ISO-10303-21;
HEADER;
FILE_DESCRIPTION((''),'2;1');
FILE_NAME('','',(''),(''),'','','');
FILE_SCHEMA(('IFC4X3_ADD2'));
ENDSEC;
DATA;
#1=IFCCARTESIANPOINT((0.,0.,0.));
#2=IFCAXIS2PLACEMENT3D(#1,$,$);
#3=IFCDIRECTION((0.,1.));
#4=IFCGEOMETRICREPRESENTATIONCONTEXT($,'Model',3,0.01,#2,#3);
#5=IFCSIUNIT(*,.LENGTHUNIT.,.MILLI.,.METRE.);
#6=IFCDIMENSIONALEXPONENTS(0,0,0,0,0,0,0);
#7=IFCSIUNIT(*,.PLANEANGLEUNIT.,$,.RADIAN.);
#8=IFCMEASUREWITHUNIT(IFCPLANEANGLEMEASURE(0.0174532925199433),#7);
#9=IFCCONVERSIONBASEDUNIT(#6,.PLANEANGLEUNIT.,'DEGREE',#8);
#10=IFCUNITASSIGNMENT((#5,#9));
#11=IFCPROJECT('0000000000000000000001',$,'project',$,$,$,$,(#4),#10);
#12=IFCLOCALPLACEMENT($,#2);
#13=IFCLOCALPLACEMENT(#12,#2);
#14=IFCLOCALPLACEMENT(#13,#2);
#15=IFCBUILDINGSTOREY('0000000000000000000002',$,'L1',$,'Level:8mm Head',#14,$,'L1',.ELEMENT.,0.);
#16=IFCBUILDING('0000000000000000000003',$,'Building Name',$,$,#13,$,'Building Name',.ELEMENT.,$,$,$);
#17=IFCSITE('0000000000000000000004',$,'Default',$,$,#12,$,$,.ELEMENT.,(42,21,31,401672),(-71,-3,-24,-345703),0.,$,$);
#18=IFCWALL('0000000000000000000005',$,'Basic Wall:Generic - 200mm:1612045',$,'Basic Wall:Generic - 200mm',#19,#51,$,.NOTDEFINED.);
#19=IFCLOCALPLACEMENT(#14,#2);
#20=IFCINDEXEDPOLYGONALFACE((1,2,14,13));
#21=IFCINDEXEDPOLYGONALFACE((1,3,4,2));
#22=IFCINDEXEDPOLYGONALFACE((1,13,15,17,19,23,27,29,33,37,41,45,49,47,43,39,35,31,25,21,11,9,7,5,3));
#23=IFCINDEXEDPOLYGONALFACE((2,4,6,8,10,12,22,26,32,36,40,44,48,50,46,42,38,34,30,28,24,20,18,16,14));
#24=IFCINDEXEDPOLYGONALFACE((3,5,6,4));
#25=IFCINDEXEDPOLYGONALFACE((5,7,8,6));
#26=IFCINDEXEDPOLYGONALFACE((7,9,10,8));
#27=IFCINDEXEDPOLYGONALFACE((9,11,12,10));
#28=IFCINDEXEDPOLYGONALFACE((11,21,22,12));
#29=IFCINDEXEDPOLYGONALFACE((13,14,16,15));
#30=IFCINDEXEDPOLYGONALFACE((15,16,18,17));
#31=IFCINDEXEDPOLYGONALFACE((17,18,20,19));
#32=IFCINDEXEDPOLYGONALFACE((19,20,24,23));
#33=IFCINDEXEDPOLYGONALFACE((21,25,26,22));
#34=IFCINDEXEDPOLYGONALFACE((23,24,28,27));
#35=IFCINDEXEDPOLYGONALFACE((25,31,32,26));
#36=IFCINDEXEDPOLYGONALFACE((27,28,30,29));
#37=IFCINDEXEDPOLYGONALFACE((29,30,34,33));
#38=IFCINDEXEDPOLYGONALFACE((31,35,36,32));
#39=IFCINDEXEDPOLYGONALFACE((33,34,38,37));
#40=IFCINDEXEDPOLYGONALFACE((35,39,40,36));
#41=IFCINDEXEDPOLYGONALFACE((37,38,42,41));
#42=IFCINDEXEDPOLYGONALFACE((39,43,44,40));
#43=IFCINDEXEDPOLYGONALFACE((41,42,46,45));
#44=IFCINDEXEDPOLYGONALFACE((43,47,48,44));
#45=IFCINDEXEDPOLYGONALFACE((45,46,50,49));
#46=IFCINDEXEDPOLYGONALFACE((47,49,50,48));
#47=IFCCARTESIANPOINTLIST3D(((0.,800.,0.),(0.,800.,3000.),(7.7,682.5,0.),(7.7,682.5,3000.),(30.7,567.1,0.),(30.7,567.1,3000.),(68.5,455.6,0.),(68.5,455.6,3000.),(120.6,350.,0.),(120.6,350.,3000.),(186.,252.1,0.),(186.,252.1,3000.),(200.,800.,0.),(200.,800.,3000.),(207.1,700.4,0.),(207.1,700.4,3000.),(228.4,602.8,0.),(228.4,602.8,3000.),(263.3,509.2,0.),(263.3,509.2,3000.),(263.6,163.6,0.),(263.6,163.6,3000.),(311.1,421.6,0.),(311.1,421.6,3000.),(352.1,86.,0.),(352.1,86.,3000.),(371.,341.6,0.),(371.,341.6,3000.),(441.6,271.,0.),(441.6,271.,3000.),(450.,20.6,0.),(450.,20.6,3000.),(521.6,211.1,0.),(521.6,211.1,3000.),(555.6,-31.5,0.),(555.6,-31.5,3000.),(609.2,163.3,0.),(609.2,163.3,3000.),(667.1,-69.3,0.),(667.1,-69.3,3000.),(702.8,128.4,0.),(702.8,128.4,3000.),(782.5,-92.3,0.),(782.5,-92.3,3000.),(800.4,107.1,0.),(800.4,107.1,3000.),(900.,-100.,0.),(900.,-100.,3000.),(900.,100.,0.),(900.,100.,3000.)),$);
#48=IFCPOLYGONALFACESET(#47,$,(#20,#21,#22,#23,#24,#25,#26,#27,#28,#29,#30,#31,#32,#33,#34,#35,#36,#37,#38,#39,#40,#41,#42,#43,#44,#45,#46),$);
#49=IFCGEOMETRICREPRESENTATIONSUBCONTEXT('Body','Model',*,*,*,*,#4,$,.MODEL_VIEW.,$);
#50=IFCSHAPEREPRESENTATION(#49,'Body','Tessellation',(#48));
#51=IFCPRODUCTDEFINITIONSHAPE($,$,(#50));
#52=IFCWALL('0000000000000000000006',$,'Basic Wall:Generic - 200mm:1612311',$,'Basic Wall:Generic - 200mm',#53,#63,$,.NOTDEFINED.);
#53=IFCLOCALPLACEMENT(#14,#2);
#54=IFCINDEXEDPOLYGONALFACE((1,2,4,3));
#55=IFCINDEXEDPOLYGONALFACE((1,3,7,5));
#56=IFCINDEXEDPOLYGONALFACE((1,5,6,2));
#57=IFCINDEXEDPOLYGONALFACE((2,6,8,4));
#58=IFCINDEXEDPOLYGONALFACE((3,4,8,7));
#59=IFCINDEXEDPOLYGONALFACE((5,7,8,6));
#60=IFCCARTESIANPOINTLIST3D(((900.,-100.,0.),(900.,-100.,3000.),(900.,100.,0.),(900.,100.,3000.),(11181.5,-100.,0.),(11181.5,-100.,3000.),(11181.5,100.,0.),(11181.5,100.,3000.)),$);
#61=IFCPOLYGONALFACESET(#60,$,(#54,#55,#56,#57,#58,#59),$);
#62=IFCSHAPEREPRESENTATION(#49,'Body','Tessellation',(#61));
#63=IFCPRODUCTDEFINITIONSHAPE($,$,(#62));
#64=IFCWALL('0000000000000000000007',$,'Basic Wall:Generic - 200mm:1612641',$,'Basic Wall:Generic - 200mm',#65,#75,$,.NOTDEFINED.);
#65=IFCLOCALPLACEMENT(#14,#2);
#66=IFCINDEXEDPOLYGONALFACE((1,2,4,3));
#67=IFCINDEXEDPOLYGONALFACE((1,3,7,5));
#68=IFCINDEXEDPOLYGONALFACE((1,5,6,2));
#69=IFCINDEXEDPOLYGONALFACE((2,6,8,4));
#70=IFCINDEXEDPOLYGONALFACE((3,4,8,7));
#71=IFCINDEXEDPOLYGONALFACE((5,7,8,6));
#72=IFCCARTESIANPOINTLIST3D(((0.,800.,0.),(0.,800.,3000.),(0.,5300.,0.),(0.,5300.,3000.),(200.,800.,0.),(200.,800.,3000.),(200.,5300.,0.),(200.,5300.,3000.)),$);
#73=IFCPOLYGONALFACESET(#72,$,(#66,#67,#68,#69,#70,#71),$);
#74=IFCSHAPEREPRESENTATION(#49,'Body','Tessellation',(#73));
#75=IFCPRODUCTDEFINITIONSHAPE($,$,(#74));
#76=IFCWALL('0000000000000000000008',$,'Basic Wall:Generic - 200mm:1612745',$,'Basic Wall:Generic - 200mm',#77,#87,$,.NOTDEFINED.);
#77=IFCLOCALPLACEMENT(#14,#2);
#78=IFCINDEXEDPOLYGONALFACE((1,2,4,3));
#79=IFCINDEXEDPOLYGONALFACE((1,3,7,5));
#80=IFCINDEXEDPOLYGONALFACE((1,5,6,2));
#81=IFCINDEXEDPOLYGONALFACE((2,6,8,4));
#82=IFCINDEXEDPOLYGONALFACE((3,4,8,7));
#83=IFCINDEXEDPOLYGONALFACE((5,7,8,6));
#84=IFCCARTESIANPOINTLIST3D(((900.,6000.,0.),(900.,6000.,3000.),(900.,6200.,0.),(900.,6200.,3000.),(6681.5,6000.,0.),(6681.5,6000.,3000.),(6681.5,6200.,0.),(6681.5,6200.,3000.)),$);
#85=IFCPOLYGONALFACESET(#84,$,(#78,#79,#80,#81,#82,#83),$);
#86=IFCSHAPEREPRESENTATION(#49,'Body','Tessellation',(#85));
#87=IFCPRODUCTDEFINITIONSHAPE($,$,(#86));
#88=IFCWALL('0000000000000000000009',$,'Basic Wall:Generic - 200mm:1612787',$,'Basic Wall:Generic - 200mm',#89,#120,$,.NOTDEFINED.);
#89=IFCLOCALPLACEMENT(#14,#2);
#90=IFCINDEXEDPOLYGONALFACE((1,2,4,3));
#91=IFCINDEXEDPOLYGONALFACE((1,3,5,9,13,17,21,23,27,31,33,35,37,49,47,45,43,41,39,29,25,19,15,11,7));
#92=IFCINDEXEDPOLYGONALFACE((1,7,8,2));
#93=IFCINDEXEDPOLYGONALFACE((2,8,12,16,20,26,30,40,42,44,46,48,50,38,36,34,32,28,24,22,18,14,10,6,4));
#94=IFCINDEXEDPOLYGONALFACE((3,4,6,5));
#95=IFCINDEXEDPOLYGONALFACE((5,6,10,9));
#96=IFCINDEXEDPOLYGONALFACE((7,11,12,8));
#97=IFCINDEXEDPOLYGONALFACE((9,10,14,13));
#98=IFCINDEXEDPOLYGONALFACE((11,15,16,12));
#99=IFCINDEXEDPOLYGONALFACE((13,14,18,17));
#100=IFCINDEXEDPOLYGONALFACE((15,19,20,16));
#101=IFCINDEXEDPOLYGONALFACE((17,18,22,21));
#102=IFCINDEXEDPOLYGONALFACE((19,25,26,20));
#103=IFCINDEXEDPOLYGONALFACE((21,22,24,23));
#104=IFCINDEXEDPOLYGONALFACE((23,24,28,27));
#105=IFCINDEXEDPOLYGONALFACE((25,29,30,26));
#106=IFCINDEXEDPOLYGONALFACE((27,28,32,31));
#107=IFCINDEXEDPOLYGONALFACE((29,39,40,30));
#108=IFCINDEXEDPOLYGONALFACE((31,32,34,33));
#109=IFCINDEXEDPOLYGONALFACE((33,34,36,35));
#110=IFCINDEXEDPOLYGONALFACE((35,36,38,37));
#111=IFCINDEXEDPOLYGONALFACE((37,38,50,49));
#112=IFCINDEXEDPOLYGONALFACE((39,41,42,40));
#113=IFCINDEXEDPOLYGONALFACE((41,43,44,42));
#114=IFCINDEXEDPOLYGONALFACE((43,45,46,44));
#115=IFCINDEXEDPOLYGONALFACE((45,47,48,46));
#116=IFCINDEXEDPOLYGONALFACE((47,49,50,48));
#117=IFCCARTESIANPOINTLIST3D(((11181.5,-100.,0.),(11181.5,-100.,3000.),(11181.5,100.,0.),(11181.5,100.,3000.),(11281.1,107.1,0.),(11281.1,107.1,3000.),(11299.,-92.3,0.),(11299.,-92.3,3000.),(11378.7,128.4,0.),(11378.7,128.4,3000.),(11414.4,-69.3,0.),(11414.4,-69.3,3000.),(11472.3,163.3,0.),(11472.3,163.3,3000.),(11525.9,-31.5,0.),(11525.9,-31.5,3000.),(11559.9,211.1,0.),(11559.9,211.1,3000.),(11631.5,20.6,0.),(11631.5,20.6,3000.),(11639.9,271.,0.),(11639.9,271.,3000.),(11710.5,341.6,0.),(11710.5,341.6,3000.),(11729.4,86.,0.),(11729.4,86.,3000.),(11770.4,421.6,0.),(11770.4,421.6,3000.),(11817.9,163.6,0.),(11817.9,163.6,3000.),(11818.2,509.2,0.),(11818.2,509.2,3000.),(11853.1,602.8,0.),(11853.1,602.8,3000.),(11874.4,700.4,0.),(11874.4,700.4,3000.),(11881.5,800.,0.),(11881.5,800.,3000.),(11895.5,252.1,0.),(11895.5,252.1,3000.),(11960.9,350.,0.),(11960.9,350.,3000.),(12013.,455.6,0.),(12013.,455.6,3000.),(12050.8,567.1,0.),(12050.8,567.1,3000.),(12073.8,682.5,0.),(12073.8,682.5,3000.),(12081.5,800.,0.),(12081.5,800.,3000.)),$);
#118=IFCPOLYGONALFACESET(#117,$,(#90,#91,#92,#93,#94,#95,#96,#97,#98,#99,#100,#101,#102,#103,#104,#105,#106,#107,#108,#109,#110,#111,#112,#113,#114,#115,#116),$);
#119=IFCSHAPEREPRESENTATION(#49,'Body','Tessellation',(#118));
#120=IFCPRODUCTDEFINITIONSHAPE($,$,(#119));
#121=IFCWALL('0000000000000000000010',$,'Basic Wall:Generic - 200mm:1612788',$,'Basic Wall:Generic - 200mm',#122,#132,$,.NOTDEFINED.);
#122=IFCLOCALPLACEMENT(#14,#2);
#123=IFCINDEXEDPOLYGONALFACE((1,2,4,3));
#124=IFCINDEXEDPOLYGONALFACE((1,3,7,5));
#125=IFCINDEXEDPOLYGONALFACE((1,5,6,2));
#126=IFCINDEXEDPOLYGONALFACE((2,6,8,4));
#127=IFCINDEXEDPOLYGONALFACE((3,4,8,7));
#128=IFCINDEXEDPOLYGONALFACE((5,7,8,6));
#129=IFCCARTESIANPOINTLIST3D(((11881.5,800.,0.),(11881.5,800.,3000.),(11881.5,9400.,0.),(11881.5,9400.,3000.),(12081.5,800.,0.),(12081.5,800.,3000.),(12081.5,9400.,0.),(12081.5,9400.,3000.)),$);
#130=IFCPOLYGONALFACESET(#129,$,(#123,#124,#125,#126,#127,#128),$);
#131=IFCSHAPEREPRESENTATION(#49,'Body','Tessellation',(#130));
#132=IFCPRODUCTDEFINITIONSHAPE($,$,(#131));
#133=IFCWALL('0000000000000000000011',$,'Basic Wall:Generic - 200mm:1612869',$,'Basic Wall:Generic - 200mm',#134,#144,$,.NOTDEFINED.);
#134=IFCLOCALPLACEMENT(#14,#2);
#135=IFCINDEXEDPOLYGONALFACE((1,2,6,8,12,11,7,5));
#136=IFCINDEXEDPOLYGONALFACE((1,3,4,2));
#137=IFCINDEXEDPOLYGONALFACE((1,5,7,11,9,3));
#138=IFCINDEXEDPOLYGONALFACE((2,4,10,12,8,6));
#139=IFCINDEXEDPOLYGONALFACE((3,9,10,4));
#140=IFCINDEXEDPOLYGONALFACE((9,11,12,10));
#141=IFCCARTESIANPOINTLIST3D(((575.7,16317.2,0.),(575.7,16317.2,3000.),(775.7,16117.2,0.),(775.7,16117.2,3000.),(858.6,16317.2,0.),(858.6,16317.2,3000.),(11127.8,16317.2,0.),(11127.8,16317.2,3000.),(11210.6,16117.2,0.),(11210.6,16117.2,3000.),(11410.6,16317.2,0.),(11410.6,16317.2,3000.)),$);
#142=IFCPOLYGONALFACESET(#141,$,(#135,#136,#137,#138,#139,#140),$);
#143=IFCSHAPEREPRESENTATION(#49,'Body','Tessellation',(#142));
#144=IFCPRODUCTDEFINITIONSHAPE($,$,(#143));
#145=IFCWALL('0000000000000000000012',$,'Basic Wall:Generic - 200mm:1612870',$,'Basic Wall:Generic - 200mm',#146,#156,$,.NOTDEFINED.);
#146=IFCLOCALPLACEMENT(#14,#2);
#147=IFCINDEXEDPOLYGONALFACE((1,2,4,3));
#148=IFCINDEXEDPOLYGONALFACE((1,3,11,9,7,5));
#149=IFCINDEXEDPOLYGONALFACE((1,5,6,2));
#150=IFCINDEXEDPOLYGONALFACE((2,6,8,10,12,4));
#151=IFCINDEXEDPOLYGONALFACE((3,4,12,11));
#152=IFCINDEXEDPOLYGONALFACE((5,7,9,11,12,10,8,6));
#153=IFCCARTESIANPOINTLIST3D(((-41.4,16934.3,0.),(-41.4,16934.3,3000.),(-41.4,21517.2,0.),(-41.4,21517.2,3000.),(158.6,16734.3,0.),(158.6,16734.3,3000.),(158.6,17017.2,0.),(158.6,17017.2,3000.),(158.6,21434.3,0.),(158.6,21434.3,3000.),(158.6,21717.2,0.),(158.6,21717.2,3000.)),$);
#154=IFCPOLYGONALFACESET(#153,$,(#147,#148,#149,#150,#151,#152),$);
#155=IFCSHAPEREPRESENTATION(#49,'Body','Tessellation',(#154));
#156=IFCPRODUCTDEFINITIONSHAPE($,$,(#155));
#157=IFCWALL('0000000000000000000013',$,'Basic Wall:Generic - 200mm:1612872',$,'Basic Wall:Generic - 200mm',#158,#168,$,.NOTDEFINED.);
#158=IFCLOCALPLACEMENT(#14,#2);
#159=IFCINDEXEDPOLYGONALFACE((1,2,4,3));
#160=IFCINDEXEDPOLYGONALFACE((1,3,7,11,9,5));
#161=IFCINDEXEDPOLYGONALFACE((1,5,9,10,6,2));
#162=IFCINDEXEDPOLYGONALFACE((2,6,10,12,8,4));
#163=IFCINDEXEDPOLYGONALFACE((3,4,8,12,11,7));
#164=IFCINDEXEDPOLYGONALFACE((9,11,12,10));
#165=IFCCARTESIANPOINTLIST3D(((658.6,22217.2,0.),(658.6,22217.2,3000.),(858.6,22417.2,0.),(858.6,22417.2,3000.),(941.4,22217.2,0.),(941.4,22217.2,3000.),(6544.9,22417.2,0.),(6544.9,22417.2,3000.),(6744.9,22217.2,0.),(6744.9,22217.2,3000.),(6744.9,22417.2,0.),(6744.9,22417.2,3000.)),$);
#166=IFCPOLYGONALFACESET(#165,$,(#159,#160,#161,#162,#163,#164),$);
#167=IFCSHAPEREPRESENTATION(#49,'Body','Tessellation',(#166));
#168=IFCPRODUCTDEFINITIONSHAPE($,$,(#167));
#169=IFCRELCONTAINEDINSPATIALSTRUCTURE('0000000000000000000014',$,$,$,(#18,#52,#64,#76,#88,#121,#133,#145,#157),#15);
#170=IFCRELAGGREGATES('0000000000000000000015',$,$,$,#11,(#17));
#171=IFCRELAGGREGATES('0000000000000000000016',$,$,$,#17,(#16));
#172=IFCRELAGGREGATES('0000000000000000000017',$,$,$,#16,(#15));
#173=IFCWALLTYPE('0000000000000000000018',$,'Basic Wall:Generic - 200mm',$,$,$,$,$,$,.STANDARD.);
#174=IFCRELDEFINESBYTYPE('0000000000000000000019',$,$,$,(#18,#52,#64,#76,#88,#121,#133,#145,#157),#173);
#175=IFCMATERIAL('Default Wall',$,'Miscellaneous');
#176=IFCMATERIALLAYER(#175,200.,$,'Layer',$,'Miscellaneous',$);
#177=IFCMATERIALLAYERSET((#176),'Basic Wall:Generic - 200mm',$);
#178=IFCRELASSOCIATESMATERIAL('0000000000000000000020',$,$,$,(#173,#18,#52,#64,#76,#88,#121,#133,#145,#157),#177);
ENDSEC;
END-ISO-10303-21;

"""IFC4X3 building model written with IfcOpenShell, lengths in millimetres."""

from ifc_helpers import new_model, entity, si_unit, converted_unit, direction, frame, frame_2d, origin, place, context, subcontext, project, spatial, polyline, circle_curve, parameter, trimmed, segment, composite_curve, rectangle, outline, extrude, material, layer, layer_set, type_object, element, save


model = new_model("IFC4X3")

# Units and contexts
model_context = context("Model", 3, precision=0.01, world=origin(), true_north=direction((0.0, 1.0)))
body_context = subcontext(model_context, "Body", "Model", "MODEL_VIEW")
ifc_project = project(units=[si_unit("LENGTHUNIT", "METRE", prefix="MILLI"), converted_unit("PLANEANGLEUNIT", "DEGREE", entity("IfcPlaneAngleMeasure", 0.0174532925199433), si_unit("PLANEANGLEUNIT", "RADIAN"), dimensions=[0, 0, 0, 0, 0, 0, 0])], contexts=[model_context])

# Site, building, storey
site_placement = place(None, origin())
site = spatial("IfcSite", under=ifc_project, at=site_placement, Name="Default", CompositionType="ELEMENT", RefLatitude=(42, 21, 31, 401672), RefLongitude=(-71, -3, -24, -345703), RefElevation=0.0)
building_placement = place(site_placement, origin())
building = spatial("IfcBuilding", under=site, at=building_placement, Name="Building Name", LongName="Building Name", CompositionType="ELEMENT")
storey_placement = place(building_placement, origin())
storey = spatial("IfcBuildingStorey", under=building, at=storey_placement, Name="L1", ObjectType="Level:8mm Head", LongName="L1", CompositionType="ELEMENT", Elevation=0.0)

# Walls
ifc_material = material(Name="Default Wall", Category="Miscellaneous")
ifc_layer = layer(ifc_material, 200.0, Name="Layer", Category="Miscellaneous")
ifc_layer_set = layer_set([ifc_layer], Name="Basic Wall:Generic - 200mm")
wall_type = type_object("IfcWallType", Name="Basic Wall:Generic - 200mm", PredefinedType="STANDARD", material=ifc_layer_set)
wall_1_placement = place(storey_placement, frame((100.0, 800.0, 0.0)))
element("IfcWall", 1, at=wall_1_placement, inside=storey, type_object=wall_type, material=ifc_layer_set, Name="Basic Wall:Generic - 200mm:1612045", ObjectType="Basic Wall:Generic - 200mm", PredefinedType="NOTDEFINED", context=body_context, shape_type="SweptSolid", body=[
    extrude(outline(composite_curve([segment(trimmed(circle_curve(frame_2d((800.0, 0.0), x_axis=(1.0, 0.0)), 700.0), [parameter(180.0)], [parameter(270.0)], True, "PARAMETER"), False, "CONTINUOUS"), segment(polyline([(100.0, 0.0), (-100.0, 0.0)]), True, "CONTINUOUS"), segment(trimmed(circle_curve(frame_2d((800.0, 0.0), x_axis=(1.0, 0.0)), 900.0), [parameter(180.0)], [parameter(270.0)], True, "PARAMETER"), True, "CONTINUOUS"), segment(polyline([(800.0, -900.0), (800.0, -700.0)]), True, "CONTINUOUS")], self_intersect=False)), origin(), (0.0, 0.0, 1.0), 3000.0),
])
wall_2_placement = place(storey_placement, frame((11181.5, 0.0, 0.0), z_axis=(0.0, 0.0, 1.0), x_axis=(-1.0, 0.0, 0.0)))
element("IfcWall", 2, at=wall_2_placement, inside=storey, type_object=wall_type, material=ifc_layer_set, Name="Basic Wall:Generic - 200mm:1612311", ObjectType="Basic Wall:Generic - 200mm", PredefinedType="NOTDEFINED", context=body_context, shape_type="SweptSolid", body=[
    extrude(rectangle(XDim=10281.5, YDim=200.0, at=frame_2d((5140.7, 0.0), x_axis=(-1.0, 0.0))), origin(), (0.0, 0.0, 1.0), 3000.0),
])
wall_3_placement = place(storey_placement, frame((100.0, 800.0, 0.0), z_axis=(0.0, 0.0, 1.0), x_axis=(0.0, 1.0, 0.0)))
element("IfcWall", 3, at=wall_3_placement, inside=storey, type_object=wall_type, material=ifc_layer_set, Name="Basic Wall:Generic - 200mm:1612641", ObjectType="Basic Wall:Generic - 200mm", PredefinedType="NOTDEFINED", context=body_context, shape_type="SweptSolid", body=[
    extrude(rectangle(XDim=4500.0, YDim=200.0, at=frame_2d((2250.0, 0.0), x_axis=(-1.0, 0.0))), origin(), (0.0, 0.0, 1.0), 3000.0),
])
wall_4_placement = place(storey_placement, frame((6681.5, 6100.0, 0.0), z_axis=(0.0, 0.0, 1.0), x_axis=(-1.0, 0.0, 0.0)))
element("IfcWall", 4, at=wall_4_placement, inside=storey, type_object=wall_type, material=ifc_layer_set, Name="Basic Wall:Generic - 200mm:1612745", ObjectType="Basic Wall:Generic - 200mm", PredefinedType="NOTDEFINED", context=body_context, shape_type="SweptSolid", body=[
    extrude(rectangle(XDim=5781.5, YDim=200.0, at=frame_2d((2890.7, 0.0), x_axis=(-1.0, 0.0))), origin(), (0.0, 0.0, 1.0), 3000.0),
])
wall_5_placement = place(storey_placement, frame((11981.5, 800.0, 0.0), z_axis=(0.0, 0.0, 1.0), x_axis=(-1.0, 0.0, 0.0)))
element("IfcWall", 5, at=wall_5_placement, inside=storey, type_object=wall_type, material=ifc_layer_set, Name="Basic Wall:Generic - 200mm:1612787", ObjectType="Basic Wall:Generic - 200mm", PredefinedType="NOTDEFINED", context=body_context, shape_type="SweptSolid", body=[
    extrude(outline(composite_curve([segment(trimmed(circle_curve(frame_2d((800.0, 0.0), x_axis=(1.0, 0.0)), 900.0), [parameter(90.0)], [parameter(180.0)], True, "PARAMETER"), True, "CONTINUOUS"), segment(polyline([(-100.0, 0.0), (100.0, 0.0)]), True, "CONTINUOUS"), segment(trimmed(circle_curve(frame_2d((800.0, 0.0), x_axis=(1.0, 0.0)), 700.0), [parameter(90.0)], [parameter(180.0)], True, "PARAMETER"), False, "CONTINUOUS"), segment(polyline([(800.0, 700.0), (800.0, 900.0)]), True, "CONTINUOUS")], self_intersect=False)), origin(), (0.0, 0.0, 1.0), 3000.0),
])
wall_6_placement = place(storey_placement, frame((11981.5, 800.0, 0.0), z_axis=(0.0, 0.0, 1.0), x_axis=(0.0, 1.0, 0.0)))
element("IfcWall", 6, at=wall_6_placement, inside=storey, type_object=wall_type, material=ifc_layer_set, Name="Basic Wall:Generic - 200mm:1612788", ObjectType="Basic Wall:Generic - 200mm", PredefinedType="NOTDEFINED", context=body_context, shape_type="SweptSolid", body=[
    extrude(rectangle(XDim=8600.0, YDim=200.0, at=frame_2d((4300.0, 0.0), x_axis=(-1.0, 0.0))), origin(), (0.0, 0.0, 1.0), 3000.0),
])
wall_7_placement = place(storey_placement, frame((11410.6, 16217.2, 0.0), z_axis=(0.0, 0.0, 1.0), x_axis=(-1.0, 0.0, 0.0)))
element("IfcWall", 7, at=wall_7_placement, inside=storey, type_object=wall_type, material=ifc_layer_set, Name="Basic Wall:Generic - 200mm:1612869", ObjectType="Basic Wall:Generic - 200mm", PredefinedType="NOTDEFINED", context=body_context, shape_type="SweptSolid", body=[
    extrude(outline(polyline([(10834.9, -100.0), (10634.9, 100.0), (200.0, 100.0), (0.0, -100.0), (282.8, -100.0), (10552.0, -100.0), (10834.9, -100.0)])), origin(), (0.0, 0.0, 1.0), 3000.0),
])
wall_8_placement = place(storey_placement, frame((58.6, 16734.3, 0.0), z_axis=(0.0, 0.0, 1.0), x_axis=(0.0, 1.0, 0.0)))
element("IfcWall", 8, at=wall_8_placement, inside=storey, type_object=wall_type, material=ifc_layer_set, Name="Basic Wall:Generic - 200mm:1612870", ObjectType="Basic Wall:Generic - 200mm", PredefinedType="NOTDEFINED", context=body_context, shape_type="SweptSolid", body=[
    extrude(outline(polyline([(4982.8, -100.0), (4782.8, 100.0), (200.0, 100.0), (0.0, -100.0), (282.8, -100.0), (4700.0, -100.0), (4982.8, -100.0)])), origin(), (0.0, 0.0, 1.0), 3000.0),
])
wall_9_placement = place(storey_placement, frame((6744.9, 22317.2, 0.0), z_axis=(0.0, 0.0, 1.0), x_axis=(-1.0, 0.0, 0.0)))
element("IfcWall", 9, at=wall_9_placement, inside=storey, type_object=wall_type, material=ifc_layer_set, Name="Basic Wall:Generic - 200mm:1612872", ObjectType="Basic Wall:Generic - 200mm", PredefinedType="NOTDEFINED", context=body_context, shape_type="SweptSolid", body=[
    extrude(outline(polyline([(5886.3, -100.0), (6086.3, 100.0), (5803.5, 100.0), (0.0, 100.0), (0.0, -100.0), (200.0, -100.0), (5886.3, -100.0)])), origin(), (0.0, 0.0, 1.0), 3000.0),
])

save(model, "model.ifc")
